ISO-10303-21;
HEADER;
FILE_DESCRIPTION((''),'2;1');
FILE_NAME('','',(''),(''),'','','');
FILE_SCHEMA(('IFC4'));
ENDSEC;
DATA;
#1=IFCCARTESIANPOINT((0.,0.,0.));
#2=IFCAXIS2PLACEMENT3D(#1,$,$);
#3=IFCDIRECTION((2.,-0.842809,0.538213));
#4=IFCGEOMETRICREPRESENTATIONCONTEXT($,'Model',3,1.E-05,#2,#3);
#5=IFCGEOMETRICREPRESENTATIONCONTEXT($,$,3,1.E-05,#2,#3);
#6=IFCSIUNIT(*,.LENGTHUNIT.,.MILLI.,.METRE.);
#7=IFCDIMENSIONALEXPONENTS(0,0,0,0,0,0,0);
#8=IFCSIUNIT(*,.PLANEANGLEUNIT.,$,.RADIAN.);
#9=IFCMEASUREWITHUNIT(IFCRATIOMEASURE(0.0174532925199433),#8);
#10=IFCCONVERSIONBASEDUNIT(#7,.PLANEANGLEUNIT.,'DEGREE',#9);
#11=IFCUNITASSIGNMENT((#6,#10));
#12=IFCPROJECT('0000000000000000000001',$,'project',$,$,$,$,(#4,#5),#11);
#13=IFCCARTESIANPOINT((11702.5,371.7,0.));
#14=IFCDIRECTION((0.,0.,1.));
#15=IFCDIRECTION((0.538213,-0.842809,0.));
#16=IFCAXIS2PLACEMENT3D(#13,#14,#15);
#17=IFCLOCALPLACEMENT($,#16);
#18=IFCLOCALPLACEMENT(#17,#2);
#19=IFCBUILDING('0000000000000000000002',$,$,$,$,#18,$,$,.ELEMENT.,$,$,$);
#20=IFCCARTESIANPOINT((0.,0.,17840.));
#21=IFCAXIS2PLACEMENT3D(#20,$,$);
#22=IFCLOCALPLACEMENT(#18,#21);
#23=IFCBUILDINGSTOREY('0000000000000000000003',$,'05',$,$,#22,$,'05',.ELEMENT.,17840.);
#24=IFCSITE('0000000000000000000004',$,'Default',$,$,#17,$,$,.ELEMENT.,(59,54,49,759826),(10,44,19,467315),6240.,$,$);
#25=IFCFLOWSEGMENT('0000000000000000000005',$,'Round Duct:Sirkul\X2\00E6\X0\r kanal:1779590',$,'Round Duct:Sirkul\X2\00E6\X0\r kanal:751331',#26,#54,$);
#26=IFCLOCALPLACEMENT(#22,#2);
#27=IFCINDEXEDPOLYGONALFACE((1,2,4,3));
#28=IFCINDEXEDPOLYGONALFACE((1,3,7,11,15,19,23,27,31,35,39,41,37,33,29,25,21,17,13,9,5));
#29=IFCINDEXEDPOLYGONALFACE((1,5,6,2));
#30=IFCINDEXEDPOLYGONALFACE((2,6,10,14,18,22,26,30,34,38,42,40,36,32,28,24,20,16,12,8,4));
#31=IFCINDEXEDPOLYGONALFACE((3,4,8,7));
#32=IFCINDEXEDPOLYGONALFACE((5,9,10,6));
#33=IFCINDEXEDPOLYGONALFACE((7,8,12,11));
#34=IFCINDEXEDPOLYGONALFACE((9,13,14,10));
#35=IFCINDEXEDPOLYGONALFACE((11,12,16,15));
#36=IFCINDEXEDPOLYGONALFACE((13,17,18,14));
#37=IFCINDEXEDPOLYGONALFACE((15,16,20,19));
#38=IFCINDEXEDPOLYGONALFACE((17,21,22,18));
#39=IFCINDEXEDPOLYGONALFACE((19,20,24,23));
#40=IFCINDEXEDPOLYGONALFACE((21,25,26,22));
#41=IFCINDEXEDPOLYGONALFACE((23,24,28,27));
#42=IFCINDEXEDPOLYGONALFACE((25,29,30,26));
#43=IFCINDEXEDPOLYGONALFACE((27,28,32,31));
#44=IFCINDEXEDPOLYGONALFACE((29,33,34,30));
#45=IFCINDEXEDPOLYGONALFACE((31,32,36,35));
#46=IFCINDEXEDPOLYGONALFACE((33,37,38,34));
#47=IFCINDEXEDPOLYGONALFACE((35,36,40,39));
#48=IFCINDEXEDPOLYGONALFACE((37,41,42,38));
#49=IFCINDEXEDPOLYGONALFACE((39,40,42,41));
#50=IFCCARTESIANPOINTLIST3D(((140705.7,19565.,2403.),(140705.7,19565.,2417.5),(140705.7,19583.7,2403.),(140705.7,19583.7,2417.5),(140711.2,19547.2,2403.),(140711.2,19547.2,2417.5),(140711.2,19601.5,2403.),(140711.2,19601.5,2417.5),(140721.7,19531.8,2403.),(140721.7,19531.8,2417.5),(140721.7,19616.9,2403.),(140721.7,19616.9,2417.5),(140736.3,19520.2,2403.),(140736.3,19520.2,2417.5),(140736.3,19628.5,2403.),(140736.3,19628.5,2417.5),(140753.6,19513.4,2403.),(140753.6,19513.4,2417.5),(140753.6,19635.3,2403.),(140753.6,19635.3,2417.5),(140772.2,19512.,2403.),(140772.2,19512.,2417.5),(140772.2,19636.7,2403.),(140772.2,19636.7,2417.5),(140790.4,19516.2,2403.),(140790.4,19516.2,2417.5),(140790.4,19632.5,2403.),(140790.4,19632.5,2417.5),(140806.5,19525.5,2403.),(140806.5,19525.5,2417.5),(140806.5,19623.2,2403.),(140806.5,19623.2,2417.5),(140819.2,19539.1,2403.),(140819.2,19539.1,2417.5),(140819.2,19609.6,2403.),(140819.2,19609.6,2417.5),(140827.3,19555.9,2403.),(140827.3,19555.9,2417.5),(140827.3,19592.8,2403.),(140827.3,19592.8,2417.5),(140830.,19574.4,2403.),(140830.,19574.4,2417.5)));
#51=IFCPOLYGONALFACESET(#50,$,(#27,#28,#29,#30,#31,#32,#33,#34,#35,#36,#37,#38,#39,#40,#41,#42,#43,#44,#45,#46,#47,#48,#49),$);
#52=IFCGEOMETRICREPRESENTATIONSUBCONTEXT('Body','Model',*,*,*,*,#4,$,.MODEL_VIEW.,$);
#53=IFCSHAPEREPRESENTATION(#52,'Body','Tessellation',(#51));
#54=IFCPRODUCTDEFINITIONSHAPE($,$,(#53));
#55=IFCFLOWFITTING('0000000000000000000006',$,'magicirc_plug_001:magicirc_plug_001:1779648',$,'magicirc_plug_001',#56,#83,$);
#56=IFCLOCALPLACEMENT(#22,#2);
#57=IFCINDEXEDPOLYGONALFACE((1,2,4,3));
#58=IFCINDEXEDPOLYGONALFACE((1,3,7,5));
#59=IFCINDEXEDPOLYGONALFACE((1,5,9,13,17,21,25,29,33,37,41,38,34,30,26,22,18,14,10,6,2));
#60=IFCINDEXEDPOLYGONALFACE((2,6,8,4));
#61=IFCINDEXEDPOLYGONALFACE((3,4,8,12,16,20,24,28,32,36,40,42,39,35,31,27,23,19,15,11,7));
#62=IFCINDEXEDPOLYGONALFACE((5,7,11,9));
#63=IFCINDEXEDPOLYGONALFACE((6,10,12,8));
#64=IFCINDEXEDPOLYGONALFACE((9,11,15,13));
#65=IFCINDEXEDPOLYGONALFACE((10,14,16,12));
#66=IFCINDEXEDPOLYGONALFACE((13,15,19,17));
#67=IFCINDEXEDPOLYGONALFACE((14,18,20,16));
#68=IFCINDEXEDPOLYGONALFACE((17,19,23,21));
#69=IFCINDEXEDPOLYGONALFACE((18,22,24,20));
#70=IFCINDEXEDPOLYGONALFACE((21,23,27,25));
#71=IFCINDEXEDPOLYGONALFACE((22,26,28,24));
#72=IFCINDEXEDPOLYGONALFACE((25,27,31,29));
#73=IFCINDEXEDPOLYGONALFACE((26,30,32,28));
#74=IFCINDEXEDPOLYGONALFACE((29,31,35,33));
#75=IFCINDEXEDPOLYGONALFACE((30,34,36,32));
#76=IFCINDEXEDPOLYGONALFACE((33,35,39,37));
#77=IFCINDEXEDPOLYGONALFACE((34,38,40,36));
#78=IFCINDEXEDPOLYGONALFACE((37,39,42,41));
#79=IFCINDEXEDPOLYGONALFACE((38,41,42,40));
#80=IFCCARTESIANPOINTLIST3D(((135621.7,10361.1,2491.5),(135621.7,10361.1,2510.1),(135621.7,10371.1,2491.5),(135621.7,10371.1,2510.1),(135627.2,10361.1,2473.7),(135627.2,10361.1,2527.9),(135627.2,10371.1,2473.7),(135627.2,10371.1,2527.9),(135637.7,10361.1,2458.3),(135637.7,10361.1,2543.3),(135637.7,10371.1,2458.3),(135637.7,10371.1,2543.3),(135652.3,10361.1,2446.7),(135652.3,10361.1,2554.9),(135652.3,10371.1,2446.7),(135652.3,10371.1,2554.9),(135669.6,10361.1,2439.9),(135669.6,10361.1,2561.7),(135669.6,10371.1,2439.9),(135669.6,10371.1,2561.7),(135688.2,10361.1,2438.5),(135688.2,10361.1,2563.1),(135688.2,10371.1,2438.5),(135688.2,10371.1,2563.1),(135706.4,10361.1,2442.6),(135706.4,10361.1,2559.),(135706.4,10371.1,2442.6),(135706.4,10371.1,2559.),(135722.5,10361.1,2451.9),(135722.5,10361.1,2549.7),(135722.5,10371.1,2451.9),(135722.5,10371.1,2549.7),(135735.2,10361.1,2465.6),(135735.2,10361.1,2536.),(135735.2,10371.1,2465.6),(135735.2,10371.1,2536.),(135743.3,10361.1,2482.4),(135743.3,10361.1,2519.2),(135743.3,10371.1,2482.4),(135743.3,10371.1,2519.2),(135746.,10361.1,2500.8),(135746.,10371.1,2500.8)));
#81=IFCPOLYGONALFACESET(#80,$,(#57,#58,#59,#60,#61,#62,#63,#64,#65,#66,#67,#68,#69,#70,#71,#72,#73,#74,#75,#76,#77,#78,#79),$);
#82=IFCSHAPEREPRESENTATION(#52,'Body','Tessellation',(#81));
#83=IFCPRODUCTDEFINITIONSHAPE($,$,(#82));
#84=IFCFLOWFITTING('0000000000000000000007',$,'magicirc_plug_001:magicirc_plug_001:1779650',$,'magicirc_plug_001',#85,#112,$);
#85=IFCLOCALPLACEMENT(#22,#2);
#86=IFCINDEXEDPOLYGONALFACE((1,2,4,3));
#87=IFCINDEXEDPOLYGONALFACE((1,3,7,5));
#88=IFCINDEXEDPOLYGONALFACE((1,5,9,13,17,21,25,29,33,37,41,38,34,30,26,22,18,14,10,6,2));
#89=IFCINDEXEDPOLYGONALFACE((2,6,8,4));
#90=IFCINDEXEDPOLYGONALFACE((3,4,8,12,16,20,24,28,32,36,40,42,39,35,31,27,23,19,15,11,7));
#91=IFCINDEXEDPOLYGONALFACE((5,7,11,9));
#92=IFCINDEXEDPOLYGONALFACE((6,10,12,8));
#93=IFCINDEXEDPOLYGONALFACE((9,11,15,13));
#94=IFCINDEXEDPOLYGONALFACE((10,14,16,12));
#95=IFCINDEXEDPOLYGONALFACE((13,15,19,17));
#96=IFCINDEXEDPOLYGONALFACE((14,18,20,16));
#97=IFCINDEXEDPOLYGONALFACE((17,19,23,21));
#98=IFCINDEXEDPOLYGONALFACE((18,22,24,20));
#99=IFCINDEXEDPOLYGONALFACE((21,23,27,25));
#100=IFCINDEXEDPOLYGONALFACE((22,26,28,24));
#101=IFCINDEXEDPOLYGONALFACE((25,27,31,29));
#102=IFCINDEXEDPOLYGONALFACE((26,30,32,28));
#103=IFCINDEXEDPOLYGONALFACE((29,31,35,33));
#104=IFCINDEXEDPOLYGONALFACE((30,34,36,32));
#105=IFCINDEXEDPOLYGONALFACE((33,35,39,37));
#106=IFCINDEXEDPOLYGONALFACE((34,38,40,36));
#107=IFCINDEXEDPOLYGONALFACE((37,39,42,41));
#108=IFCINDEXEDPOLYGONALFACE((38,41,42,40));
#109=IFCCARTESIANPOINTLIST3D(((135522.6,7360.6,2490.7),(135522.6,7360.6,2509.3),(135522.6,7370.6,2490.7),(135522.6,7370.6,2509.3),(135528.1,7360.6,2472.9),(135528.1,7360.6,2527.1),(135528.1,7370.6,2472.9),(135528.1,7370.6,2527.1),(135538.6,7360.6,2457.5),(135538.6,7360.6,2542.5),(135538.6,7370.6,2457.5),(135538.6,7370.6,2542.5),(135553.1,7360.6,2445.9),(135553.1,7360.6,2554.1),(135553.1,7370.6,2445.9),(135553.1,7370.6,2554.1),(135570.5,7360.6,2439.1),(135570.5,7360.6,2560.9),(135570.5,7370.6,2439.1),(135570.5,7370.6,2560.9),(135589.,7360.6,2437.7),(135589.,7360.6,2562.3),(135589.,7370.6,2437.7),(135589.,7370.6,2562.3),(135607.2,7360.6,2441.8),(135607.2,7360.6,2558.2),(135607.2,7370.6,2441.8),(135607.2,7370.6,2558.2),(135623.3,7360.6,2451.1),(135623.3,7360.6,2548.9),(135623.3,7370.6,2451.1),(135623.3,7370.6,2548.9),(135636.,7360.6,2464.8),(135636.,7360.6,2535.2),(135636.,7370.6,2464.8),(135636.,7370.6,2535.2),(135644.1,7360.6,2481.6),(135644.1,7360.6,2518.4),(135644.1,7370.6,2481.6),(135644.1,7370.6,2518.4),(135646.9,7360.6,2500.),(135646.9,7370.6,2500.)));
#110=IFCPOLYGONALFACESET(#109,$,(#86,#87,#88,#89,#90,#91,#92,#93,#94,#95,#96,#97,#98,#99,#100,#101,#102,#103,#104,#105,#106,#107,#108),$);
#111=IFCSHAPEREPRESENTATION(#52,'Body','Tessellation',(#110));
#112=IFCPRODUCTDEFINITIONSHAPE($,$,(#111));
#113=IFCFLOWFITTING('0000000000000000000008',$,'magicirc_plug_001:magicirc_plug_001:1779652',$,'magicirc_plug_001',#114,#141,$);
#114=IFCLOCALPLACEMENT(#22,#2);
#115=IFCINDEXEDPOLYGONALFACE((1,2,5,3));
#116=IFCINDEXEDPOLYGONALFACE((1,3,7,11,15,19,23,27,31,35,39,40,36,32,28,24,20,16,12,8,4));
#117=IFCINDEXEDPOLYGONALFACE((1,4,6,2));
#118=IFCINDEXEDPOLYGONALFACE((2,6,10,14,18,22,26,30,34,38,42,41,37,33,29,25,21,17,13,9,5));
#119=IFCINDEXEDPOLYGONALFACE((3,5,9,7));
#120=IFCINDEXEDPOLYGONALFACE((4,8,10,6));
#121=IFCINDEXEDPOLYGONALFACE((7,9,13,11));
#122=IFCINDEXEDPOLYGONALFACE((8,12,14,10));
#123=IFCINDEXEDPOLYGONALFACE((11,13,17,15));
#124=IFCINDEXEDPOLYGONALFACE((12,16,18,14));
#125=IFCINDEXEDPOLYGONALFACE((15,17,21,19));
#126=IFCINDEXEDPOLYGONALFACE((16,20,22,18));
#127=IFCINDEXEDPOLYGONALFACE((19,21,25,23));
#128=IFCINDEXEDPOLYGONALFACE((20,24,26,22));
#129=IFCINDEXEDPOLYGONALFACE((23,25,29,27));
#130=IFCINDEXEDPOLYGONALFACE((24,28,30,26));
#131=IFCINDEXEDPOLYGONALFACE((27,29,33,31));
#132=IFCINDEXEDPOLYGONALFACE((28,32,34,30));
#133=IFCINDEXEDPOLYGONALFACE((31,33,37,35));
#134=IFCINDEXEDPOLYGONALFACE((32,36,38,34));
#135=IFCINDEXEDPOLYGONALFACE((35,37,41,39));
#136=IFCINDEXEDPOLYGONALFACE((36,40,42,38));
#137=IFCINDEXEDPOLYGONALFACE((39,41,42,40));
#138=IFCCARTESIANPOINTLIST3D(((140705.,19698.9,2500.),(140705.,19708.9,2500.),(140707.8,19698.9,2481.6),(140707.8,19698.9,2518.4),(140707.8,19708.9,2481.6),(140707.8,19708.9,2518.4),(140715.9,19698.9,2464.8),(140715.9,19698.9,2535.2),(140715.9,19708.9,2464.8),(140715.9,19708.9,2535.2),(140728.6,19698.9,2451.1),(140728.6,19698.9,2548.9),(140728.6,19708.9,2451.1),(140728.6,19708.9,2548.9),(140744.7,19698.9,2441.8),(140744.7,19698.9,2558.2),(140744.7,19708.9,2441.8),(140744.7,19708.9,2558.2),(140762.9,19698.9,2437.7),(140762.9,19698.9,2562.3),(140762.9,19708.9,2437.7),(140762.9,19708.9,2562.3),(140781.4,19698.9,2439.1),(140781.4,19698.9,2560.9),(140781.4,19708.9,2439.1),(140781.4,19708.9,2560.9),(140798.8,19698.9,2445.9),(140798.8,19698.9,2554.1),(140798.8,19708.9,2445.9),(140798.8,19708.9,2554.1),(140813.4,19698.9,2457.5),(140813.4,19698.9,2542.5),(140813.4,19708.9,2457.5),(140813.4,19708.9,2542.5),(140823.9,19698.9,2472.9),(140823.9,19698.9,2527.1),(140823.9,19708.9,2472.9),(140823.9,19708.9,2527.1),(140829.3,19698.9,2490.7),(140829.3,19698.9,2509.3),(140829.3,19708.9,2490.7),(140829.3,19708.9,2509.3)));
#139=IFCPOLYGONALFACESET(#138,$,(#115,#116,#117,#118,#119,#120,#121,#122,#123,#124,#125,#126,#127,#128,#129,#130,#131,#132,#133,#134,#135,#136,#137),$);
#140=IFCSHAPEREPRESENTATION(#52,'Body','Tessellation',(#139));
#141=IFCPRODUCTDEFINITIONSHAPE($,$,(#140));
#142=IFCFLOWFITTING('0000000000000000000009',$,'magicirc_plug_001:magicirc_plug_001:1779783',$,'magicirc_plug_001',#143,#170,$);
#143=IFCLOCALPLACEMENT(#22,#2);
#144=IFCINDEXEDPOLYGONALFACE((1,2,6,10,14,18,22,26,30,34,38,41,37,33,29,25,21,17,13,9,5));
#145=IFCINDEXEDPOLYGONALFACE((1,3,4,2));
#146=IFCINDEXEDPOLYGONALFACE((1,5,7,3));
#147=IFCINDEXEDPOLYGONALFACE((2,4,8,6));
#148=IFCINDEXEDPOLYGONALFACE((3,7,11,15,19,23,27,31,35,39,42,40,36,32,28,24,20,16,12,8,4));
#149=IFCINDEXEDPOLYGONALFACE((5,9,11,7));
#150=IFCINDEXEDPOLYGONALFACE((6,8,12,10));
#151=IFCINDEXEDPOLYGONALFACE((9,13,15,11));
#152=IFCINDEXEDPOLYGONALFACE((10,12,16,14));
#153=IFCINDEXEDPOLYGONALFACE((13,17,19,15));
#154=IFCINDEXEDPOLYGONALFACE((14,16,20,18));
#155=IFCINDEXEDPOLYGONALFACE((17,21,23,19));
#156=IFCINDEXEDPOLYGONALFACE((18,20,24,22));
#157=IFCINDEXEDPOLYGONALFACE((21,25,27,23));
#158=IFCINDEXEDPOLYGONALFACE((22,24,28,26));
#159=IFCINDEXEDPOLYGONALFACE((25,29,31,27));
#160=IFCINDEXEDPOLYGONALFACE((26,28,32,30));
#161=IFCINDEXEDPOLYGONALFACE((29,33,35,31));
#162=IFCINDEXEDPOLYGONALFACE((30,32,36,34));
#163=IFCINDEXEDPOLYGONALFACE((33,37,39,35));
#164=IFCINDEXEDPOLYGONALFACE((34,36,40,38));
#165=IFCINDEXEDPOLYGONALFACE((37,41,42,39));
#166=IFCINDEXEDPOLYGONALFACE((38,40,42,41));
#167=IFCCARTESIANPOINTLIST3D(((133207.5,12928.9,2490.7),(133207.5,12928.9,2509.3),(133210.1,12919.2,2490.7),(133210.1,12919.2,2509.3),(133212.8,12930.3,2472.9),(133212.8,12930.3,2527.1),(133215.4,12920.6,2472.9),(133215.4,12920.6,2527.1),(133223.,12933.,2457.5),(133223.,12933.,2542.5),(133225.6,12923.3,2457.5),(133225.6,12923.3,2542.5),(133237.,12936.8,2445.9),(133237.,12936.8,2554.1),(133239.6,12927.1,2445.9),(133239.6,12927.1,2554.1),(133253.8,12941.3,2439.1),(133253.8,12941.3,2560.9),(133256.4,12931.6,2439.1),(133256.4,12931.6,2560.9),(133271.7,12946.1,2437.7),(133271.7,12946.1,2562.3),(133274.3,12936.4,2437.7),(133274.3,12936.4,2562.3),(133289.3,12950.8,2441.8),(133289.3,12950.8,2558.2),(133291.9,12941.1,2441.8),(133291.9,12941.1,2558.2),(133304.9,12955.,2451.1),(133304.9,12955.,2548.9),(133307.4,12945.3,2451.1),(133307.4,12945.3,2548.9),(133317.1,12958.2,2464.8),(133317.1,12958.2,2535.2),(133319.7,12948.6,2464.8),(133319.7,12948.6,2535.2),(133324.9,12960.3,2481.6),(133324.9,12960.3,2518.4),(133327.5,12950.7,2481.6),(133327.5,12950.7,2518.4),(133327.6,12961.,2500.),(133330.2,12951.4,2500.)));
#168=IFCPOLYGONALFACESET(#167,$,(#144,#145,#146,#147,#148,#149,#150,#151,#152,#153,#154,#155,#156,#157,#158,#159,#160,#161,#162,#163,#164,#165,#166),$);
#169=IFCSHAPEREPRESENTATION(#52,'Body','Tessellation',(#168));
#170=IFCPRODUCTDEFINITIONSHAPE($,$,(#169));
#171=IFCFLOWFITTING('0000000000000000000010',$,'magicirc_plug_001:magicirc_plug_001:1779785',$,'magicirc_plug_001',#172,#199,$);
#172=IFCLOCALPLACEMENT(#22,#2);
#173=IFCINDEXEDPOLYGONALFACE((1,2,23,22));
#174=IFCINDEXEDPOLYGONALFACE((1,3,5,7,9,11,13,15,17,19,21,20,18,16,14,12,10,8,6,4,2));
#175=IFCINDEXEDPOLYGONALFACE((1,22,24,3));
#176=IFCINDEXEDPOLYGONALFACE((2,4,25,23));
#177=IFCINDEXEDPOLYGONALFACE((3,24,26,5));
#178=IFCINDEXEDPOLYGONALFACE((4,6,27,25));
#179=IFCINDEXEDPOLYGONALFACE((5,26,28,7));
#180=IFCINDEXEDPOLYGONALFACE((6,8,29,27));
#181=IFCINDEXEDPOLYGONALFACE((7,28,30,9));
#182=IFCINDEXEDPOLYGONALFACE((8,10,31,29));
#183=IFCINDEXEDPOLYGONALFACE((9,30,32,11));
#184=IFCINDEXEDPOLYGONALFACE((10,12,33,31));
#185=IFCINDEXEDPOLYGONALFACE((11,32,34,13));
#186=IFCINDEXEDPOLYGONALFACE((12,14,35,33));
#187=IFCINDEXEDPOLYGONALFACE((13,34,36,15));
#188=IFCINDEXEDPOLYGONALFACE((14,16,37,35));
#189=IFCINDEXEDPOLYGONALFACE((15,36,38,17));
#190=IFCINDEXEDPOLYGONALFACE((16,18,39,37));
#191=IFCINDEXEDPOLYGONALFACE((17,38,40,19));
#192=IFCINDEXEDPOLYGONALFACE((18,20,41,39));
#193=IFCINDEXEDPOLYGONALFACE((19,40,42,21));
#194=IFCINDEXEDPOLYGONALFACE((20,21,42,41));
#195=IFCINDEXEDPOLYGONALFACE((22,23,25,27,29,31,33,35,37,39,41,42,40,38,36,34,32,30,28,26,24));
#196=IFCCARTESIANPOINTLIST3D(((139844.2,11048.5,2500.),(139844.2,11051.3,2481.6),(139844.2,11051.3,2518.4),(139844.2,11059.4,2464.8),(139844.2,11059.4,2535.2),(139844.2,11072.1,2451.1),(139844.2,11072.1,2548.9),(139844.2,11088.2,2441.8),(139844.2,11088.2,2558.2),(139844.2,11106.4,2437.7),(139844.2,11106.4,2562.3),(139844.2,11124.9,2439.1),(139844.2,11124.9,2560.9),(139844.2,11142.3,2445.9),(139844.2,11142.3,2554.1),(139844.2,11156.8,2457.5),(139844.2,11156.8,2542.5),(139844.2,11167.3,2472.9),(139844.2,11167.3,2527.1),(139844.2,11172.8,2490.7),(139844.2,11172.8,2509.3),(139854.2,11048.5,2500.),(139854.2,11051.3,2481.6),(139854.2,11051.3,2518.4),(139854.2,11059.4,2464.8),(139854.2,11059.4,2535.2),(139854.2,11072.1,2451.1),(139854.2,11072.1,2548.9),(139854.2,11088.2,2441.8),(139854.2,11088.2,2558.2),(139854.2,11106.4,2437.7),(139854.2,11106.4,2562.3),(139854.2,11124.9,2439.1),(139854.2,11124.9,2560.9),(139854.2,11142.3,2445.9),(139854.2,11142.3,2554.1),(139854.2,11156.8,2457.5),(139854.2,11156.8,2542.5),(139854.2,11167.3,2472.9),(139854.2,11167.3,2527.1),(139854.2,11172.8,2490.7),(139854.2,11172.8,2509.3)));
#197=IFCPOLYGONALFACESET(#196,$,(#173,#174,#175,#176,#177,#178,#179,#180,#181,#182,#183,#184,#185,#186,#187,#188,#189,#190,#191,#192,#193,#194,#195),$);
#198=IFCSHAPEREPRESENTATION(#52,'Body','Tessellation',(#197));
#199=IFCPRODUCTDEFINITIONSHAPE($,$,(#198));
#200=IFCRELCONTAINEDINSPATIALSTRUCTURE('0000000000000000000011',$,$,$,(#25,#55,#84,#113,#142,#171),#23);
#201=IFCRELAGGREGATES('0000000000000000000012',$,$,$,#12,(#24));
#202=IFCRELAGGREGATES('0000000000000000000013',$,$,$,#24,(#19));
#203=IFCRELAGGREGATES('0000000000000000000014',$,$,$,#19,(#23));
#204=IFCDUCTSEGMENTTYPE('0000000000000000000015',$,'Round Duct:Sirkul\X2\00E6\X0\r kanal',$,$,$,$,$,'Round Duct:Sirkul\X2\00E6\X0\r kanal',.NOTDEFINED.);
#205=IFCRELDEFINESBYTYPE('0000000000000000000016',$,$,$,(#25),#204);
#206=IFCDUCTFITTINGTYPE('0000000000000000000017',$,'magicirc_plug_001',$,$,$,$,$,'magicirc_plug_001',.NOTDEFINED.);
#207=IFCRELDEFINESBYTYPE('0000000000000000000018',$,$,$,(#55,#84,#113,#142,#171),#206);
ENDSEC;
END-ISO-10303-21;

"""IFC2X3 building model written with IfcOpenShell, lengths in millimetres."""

from ifc_helpers import new_model, entity, si_unit, converted_unit, direction, frame, frame_2d, origin, place, context, subcontext, project, spatial, circle, extrude, source, transform, mapped, type_object, type_shapes, element, save


model = new_model("IFC2X3")

# Units and contexts
model_context = context("Model", 3, precision=1e-05, world=origin(), true_north=direction((2.0, -0.842809, 0.538213)))
context_of_model = context(None, 3, precision=1e-05, world=origin(), true_north=direction((2.0, -0.842809, 0.538213)))
body_context = subcontext(model_context, "Body", "Model", "MODEL_VIEW")
ifc_project = project(units=[si_unit("LENGTHUNIT", "METRE", prefix="MILLI"), converted_unit("PLANEANGLEUNIT", "DEGREE", entity("IfcRatioMeasure", 0.0174532925199433), si_unit("PLANEANGLEUNIT", "RADIAN"), dimensions=[0, 0, 0, 0, 0, 0, 0])], contexts=[model_context, context_of_model])

# Site, building, storey
site_placement = place(None, frame((11702.5, 371.7, 0.0), z_axis=(0.0, 0.0, 1.0), x_axis=(0.538213, -0.842809, 0.0)))
site = spatial("IfcSite", under=ifc_project, at=site_placement, Name="Default", CompositionType="ELEMENT", RefLatitude=(59, 54, 49, 759826), RefLongitude=(10, 44, 19, 467315), RefElevation=6240.0)
building_placement = place(site_placement, origin())
building = spatial("IfcBuilding", under=site, at=building_placement, CompositionType="ELEMENT")
storey_placement = place(building_placement, frame((0.0, 0.0, 17840.0)))
storey = spatial("IfcBuildingStorey", under=building, at=storey_placement, Name="05", LongName="05", CompositionType="ELEMENT", Elevation=17840.0)

# Flow segment
duct_segment_type = type_object("IfcDuctSegmentType", Name="Round Duct:Sirkulær kanal", ElementType="Round Duct:Sirkulær kanal", PredefinedType="NOTDEFINED")
flow_segment_1_placement = place(storey_placement, origin())
element("IfcFlowSegment", 1, at=flow_segment_1_placement, inside=storey, type_object=duct_segment_type, Name="Round Duct:Sirkulær kanal:1779590", ObjectType="Round Duct:Sirkulær kanal:751331", context=body_context, shape_type="SweptSolid", body=[
    extrude(circle(Radius=62.5, at=frame_2d((0.0, 0.0), x_axis=(1.0, 0.0))), frame((140767.5, 19574.4, 2403.0)), (0.0, 0.0, 1.0), 14.5),
])

# Flow fittings
duct_fitting_type_1 = type_object("IfcDuctFittingType", Name="magicirc_plug_001", ElementType="magicirc_plug_001", PredefinedType="NOTDEFINED")
shared_shape_1 = source(origin(), body_context, "Body", "SweptSolid", [
    extrude(circle(Radius=62.5, at=frame_2d((0.0, 0.0), x_axis=(1.0, 0.0))), frame((0.0, 0.0, 0.0), z_axis=(1.0, 0.0, 0.0), x_axis=(0.0, 1.0, 0.0)), (0.0, 0.0, 1.0), 10.0),
])
type_shapes(duct_fitting_type_1, [shared_shape_1])
for number, where, z_axis, x_axis, name in (
    (2, (135683.5, 10371.1, 2500.8), (0.0, 0.0, 1.0), (0.0, -1.0, 0.0), "magicirc_plug_001:magicirc_plug_001:1779648"),
    (3, (135584.4, 7370.6, 2500.0), (0.0, 0.0, 1.0), (0.0, -1.0, 0.0), "magicirc_plug_001:magicirc_plug_001:1779650"),
    (4, (140767.5, 19698.9, 2500.0), (0.0, 0.0, 1.0), (0.0, 1.0, 0.0), "magicirc_plug_001:magicirc_plug_001:1779652"),
    (5, (133267.2, 12944.9, 2500.0), (0.0, 0.0, 1.0), (0.258819, -0.965926, 0.0), "magicirc_plug_001:magicirc_plug_001:1779783"),
    (6, (139854.2, 11111.0, 2500.0), (0.0, 0.0, 1.0), (-1.0, 0.0, 0.0), "magicirc_plug_001:magicirc_plug_001:1779785"),
):
    element("IfcFlowFitting", number, at=place(storey_placement, frame(where, z_axis=z_axis, x_axis=x_axis)), inside=storey, type_object=duct_fitting_type_1, Name=name, ObjectType="magicirc_plug_001", context=body_context, shape_type="MappedRepresentation", body=[
        mapped(shared_shape_1, transform((0.0, 0.0, 0.0), scale=1.0)),
    ])

save(model, "model.ifc")
